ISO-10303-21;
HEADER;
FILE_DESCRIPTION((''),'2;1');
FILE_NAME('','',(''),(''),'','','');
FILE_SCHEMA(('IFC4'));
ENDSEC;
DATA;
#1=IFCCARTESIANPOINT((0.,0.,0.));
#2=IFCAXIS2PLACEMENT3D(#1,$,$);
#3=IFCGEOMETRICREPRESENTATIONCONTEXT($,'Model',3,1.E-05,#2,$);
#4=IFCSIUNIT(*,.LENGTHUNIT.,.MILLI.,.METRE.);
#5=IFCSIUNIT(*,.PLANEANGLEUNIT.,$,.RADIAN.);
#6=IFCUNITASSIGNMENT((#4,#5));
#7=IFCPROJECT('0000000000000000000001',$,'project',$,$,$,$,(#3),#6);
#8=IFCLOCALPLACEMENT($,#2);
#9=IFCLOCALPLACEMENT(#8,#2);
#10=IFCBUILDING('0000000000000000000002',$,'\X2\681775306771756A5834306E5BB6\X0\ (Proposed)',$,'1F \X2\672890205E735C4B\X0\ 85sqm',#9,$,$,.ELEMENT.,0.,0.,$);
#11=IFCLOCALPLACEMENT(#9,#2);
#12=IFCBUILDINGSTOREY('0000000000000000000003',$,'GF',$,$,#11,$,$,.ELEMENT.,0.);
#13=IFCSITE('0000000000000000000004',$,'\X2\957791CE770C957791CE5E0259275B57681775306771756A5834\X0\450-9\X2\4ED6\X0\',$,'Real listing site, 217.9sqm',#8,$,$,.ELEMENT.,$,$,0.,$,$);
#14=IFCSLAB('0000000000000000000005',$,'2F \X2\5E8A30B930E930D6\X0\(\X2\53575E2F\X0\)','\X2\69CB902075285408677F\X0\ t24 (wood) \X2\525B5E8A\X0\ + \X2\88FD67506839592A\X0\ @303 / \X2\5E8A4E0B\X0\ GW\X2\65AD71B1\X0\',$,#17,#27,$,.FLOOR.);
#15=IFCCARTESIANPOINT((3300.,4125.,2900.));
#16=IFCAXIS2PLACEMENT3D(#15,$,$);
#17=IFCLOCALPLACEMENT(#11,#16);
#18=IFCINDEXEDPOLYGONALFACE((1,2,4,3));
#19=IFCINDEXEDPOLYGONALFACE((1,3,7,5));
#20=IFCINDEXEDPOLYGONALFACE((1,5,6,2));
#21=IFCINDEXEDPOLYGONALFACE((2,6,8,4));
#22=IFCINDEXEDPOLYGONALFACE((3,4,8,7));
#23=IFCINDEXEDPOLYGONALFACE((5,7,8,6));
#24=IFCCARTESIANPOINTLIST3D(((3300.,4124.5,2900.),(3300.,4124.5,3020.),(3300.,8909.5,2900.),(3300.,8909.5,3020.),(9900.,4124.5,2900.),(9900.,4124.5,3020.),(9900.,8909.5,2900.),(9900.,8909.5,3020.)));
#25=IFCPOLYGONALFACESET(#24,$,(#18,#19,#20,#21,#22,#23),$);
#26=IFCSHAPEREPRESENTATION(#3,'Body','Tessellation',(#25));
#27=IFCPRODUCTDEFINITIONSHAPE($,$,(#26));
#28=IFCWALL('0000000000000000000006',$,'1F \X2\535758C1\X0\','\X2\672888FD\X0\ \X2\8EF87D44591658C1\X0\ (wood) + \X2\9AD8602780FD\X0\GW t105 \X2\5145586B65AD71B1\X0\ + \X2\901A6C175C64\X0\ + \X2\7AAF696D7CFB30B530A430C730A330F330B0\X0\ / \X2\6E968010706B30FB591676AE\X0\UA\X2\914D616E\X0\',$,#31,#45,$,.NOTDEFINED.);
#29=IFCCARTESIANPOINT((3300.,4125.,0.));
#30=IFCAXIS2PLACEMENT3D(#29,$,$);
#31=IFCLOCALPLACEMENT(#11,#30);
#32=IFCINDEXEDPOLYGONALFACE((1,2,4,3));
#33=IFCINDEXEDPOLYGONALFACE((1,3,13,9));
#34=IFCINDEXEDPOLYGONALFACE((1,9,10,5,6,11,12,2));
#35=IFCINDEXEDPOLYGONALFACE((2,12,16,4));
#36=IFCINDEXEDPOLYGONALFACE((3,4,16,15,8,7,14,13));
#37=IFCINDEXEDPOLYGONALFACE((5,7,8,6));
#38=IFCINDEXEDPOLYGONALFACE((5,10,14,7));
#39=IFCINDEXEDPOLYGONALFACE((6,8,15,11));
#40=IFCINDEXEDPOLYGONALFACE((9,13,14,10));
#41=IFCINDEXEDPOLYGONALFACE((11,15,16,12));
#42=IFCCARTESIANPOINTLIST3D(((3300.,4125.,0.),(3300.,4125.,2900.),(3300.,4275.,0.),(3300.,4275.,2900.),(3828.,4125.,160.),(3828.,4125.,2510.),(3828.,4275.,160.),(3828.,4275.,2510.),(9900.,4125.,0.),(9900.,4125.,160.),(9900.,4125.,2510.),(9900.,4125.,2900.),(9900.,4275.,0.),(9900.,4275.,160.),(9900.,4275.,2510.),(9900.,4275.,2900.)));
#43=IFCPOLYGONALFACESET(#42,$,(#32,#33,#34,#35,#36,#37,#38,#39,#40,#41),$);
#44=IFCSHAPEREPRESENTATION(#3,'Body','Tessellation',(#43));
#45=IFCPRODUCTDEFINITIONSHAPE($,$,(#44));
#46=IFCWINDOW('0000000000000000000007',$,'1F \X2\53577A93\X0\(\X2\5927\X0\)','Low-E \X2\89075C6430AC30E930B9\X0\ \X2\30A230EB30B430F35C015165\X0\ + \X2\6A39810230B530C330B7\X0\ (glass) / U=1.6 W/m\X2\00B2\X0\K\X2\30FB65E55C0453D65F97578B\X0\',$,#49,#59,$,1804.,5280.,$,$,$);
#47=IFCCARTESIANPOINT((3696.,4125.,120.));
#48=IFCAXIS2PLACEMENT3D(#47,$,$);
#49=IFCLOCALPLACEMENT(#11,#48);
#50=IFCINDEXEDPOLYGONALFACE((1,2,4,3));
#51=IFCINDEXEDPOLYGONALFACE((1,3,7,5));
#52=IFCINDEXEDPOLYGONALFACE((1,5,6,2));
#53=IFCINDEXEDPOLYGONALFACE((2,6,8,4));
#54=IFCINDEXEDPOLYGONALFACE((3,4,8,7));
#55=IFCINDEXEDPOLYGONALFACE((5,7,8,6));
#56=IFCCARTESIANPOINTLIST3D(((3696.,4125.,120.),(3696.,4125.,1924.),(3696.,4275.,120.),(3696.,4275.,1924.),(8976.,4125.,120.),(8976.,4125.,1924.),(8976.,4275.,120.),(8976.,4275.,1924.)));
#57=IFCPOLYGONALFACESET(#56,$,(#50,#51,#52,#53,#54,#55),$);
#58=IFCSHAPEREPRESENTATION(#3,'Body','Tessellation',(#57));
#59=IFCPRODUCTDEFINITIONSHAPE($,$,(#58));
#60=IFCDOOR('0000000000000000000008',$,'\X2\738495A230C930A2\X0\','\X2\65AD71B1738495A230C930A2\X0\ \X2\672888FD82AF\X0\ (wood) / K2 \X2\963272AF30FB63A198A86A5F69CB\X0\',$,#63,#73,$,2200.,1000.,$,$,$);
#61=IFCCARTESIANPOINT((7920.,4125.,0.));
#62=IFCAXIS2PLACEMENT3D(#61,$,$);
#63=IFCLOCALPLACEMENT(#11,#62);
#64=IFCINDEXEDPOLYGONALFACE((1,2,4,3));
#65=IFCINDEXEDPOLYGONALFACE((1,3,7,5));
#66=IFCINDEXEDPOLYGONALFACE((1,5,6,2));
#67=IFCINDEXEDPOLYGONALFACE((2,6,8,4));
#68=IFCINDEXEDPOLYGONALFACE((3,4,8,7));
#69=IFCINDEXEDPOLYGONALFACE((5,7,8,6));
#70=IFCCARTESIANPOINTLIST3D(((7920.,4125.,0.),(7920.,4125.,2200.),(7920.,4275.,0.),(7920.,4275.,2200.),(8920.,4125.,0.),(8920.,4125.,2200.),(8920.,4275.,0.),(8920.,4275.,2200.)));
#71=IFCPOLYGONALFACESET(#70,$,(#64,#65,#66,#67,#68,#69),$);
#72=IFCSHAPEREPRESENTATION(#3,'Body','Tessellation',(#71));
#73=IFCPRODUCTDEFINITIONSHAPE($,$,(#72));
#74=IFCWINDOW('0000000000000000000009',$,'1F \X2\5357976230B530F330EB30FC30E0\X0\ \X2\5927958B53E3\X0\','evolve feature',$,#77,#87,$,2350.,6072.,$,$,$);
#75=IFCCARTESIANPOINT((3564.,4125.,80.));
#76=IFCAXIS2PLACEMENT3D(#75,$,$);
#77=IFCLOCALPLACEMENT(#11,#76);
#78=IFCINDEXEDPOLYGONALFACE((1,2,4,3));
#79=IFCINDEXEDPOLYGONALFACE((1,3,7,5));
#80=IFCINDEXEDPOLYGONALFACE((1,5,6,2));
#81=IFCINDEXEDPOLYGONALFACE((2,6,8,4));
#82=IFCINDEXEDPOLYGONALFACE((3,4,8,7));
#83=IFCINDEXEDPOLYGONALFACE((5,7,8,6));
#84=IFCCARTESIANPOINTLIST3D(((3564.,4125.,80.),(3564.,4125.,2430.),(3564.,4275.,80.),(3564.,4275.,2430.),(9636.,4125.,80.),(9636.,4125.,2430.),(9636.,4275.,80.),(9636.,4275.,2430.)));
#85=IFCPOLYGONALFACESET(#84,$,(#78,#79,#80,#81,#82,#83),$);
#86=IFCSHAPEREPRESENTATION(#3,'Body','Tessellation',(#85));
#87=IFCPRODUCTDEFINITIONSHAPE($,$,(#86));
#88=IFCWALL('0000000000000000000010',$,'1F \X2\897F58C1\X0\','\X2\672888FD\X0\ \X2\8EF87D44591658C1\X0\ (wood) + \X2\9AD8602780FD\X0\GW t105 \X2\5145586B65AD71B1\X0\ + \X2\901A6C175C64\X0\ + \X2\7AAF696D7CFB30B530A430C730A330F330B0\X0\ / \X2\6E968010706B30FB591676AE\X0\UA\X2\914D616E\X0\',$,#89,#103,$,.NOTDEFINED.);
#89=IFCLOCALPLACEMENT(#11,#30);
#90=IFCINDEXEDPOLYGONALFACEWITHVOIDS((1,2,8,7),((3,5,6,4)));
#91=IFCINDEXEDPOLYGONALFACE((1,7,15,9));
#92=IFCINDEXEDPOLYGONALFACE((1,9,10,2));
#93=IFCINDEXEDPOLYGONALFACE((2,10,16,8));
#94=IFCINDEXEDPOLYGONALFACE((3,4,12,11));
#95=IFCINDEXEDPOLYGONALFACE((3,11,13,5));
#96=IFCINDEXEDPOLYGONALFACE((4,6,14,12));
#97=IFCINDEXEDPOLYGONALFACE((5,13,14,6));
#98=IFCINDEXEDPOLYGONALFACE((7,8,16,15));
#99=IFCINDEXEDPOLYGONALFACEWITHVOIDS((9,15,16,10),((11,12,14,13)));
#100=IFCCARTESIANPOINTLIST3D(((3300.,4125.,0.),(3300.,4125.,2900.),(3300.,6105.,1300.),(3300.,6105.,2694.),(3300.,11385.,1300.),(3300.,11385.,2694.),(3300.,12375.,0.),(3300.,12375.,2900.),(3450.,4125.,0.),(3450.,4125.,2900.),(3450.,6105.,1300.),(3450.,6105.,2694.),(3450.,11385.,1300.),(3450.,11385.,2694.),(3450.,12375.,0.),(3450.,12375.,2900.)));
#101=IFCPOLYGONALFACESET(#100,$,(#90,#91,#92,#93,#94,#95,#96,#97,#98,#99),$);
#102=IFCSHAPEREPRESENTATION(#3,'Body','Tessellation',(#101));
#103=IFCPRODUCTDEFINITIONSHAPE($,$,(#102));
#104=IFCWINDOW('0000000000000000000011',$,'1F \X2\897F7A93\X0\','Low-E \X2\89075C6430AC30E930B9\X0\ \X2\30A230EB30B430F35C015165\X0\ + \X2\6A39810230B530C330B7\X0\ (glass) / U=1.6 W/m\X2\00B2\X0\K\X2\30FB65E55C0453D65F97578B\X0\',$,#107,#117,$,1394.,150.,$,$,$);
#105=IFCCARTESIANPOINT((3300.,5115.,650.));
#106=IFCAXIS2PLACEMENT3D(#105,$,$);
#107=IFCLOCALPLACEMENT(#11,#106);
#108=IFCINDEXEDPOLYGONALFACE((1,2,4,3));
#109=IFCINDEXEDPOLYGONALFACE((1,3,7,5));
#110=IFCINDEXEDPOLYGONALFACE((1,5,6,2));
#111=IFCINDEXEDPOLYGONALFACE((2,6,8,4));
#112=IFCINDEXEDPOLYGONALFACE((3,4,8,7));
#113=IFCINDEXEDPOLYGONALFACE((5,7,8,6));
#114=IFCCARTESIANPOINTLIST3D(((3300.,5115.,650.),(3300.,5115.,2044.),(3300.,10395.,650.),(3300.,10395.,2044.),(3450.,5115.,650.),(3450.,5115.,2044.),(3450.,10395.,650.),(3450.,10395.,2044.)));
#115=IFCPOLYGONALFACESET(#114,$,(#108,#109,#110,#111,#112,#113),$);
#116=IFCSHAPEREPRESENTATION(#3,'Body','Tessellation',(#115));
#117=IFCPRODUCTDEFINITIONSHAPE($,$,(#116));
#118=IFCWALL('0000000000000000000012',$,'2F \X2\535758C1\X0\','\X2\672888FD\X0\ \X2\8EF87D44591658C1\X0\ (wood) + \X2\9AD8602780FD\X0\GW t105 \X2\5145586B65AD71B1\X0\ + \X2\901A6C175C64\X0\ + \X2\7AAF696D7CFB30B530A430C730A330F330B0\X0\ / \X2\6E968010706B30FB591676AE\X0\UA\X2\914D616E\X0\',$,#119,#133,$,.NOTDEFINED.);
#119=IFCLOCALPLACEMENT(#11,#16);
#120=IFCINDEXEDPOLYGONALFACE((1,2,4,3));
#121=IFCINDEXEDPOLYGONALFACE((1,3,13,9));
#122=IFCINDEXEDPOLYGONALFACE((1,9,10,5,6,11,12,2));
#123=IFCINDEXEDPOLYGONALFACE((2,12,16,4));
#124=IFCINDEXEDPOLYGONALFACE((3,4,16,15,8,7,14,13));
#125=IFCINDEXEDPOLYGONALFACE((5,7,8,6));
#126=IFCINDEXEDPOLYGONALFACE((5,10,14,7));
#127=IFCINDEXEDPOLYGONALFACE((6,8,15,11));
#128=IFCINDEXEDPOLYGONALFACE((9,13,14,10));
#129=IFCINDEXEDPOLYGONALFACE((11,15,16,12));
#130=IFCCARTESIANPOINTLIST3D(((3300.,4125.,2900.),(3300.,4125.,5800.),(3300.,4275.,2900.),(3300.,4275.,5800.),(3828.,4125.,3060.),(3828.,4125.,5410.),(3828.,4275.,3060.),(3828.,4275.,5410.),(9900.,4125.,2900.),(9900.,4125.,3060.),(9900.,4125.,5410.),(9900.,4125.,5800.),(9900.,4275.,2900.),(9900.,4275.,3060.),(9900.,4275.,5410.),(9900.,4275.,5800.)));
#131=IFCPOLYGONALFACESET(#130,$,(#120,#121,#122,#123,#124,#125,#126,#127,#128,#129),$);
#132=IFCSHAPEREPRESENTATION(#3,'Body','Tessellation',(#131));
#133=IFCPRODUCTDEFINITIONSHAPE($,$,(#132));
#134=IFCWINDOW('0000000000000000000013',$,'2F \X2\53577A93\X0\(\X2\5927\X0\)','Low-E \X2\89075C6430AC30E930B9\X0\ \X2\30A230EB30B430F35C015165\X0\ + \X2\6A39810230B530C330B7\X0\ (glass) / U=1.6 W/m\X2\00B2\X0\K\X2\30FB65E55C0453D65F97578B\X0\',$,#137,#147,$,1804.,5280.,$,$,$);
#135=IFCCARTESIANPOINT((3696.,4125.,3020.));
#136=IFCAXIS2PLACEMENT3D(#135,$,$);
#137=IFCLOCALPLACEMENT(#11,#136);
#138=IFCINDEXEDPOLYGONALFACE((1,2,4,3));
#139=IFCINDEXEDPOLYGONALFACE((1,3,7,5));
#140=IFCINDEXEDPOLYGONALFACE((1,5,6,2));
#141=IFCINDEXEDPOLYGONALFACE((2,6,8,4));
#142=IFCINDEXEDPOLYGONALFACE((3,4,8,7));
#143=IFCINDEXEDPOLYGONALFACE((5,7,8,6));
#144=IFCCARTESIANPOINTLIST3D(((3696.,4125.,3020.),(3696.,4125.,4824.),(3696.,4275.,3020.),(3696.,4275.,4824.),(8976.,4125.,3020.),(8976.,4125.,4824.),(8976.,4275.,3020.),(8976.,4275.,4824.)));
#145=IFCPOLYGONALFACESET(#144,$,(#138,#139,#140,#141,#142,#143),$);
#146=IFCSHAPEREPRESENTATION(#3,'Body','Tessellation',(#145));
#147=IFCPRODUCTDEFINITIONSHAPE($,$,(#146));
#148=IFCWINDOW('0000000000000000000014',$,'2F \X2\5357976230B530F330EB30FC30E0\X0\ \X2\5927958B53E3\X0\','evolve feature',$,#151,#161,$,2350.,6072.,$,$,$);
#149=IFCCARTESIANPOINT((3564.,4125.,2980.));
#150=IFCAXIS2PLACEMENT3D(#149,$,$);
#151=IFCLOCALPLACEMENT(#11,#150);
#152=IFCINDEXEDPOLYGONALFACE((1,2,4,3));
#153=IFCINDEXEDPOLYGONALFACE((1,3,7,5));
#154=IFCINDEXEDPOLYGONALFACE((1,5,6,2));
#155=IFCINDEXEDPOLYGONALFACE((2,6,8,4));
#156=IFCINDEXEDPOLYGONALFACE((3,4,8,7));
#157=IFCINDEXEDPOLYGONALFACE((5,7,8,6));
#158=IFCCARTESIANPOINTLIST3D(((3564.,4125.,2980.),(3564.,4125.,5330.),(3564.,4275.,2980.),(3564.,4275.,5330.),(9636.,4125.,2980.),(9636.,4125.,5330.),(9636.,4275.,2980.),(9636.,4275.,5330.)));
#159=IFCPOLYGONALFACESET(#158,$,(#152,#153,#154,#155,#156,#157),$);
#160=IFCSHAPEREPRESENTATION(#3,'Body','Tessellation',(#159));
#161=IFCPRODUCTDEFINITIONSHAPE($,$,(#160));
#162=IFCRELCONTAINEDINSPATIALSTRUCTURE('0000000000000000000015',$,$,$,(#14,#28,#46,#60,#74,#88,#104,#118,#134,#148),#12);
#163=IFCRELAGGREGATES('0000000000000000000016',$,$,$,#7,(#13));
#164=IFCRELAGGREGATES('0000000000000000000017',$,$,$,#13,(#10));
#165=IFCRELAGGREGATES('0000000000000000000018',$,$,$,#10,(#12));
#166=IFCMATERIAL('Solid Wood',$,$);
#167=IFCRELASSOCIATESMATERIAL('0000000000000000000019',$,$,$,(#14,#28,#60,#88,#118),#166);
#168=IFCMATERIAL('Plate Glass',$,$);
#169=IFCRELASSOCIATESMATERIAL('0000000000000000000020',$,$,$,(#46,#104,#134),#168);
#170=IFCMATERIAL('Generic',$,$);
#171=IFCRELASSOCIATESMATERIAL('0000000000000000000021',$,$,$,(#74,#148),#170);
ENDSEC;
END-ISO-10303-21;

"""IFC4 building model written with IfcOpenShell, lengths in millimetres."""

from ifc_helpers import new_model, si_unit, frame, frame_2d, origin, place, context, project, spatial, rectangle, extrude, material, element, fill, save


model = new_model("IFC4")

# Units and contexts
model_context = context("Model", 3, precision=1e-05, world=origin())
ifc_project = project(units=[si_unit("LENGTHUNIT", "METRE", prefix="MILLI"), si_unit("PLANEANGLEUNIT", "RADIAN")], contexts=[model_context])

# Site, building, storey
site_placement = place(None, origin())
site = spatial("IfcSite", under=ifc_project, at=site_placement, Name="長野県長野市大字栗田東番場450-9他", ObjectType="Real listing site, 217.9sqm", CompositionType="ELEMENT", RefElevation=0.0)
building_placement = place(site_placement, origin())
building = spatial("IfcBuilding", under=site, at=building_placement, Name="栗田東番場の家 (Proposed)", ObjectType="1F 木造平屋 85sqm", CompositionType="ELEMENT", ElevationOfRefHeight=0.0, ElevationOfTerrain=0.0)
storey_placement = place(building_placement, origin())
storey = spatial("IfcBuildingStorey", under=building, at=storey_placement, Name="GF", CompositionType="ELEMENT", Elevation=0.0)

# Slab
ifc_material_1 = material(Name="Solid Wood")
slab_1_placement = place(storey_placement, frame((3300.0, 4125.0, 2900.0)))
element("IfcSlab", 1, at=slab_1_placement, inside=storey, material=ifc_material_1, Name="2F 床スラブ(南帯)", Description="構造用合板 t24 (wood) 剛床 + 製材根太 @303 / 床下 GW断熱", PredefinedType="FLOOR", context=model_context, shape_type="SweptSolid", body=[
    extrude(rectangle(XDim=6600.0, YDim=4785.0, at=frame_2d((3300.0, 2392.0))), frame((3300.0, 4125.0, 2900.0)), (0.0, 0.0, 1.0), 120.0),
])
ifc_material_2 = material(Name="Generic")

# Wall, openings, windows, door
wall_1_placement = place(storey_placement, frame((3300.0, 4125.0, 0.0)))
wall_1 = element("IfcWall", 2, at=wall_1_placement, inside=storey, material=ifc_material_1, Name="1F 南壁", Description="木製 軸組外壁 (wood) + 高性能GW t105 充填断熱 + 通気層 + 窯業系サイディング / 準耐火・外皮UA配慮", PredefinedType="NOTDEFINED", context=model_context, shape_type="SweptSolid", body=[
    extrude(rectangle(XDim=6600.0, YDim=150.0, at=frame_2d((3300.0, 75.0))), frame((3300.0, 4125.0, 0.0)), (0.0, 0.0, 1.0), 2900.0),
])
opening_1_placement = place(storey_placement, frame((3696.0, 4125.0, 120.0)))
opening_1 = element("IfcOpeningElement", 3, at=opening_1_placement, cuts=wall_1, PredefinedType="NOTDEFINED", context=model_context, shape_type="SweptSolid", body=[
    extrude(rectangle(XDim=5280.0, YDim=150.0, at=frame_2d((2640.0, 75.0))), frame((3696.0, 4125.0, 120.0)), (0.0, 0.0, 1.0), 1804.0),
])
opening_2_placement = place(storey_placement, frame((7920.0, 4125.0, 0.0)))
opening_2 = element("IfcOpeningElement", 4, at=opening_2_placement, cuts=wall_1, PredefinedType="NOTDEFINED", context=model_context, shape_type="SweptSolid", body=[
    extrude(rectangle(XDim=1000.0, YDim=150.0, at=frame_2d((500.0, 75.0))), frame((7920.0, 4125.0, 0.0)), (0.0, 0.0, 1.0), 2200.0),
])
opening_3_placement = place(storey_placement, frame((3564.0, 4125.0, 80.0)))
opening_3 = element("IfcOpeningElement", 5, at=opening_3_placement, cuts=wall_1, PredefinedType="NOTDEFINED", context=model_context, shape_type="SweptSolid", body=[
    extrude(rectangle(XDim=6072.0, YDim=150.0, at=frame_2d((3036.0, 75.0))), frame((3564.0, 4125.0, 80.0)), (0.0, 0.0, 1.0), 2350.0),
])
ifc_material_3 = material(Name="Plate Glass")
window_1_placement = place(storey_placement, frame((3696.0, 4125.0, 120.0)))
window_1 = element("IfcWindow", 6, at=window_1_placement, inside=storey, material=ifc_material_3, Name="1F 南窓(大)", Description="Low-E 複層ガラス アルゴン封入 + 樹脂サッシ (glass) / U=1.6 W/m²K・日射取得型", OverallHeight=1804.0, OverallWidth=5280.0, context=model_context, shape_type="SweptSolid", body=[
    extrude(rectangle(XDim=5280.0, YDim=150.0, at=frame_2d((2640.0, 75.0))), frame((3696.0, 4125.0, 120.0)), (0.0, 0.0, 1.0), 1804.0),
])
fill(opening_1, window_1)
door_placement = place(storey_placement, frame((7920.0, 4125.0, 0.0)))
door = element("IfcDoor", 7, at=door_placement, inside=storey, material=ifc_material_1, Name="玄関ドア", Description="断熱玄関ドア 木製芯 (wood) / K2 防犯・採風機構", OverallHeight=2200.0, OverallWidth=1000.0, context=model_context, shape_type="SweptSolid", body=[
    extrude(rectangle(XDim=1000.0, YDim=150.0, at=frame_2d((500.0, 75.0))), frame((7920.0, 4125.0, 0.0)), (0.0, 0.0, 1.0), 2200.0),
])
fill(opening_2, door)
window_2_placement = place(storey_placement, frame((3564.0, 4125.0, 80.0)))
window_2 = element("IfcWindow", 8, at=window_2_placement, inside=storey, material=ifc_material_2, Name="1F 南面サンルーム 大開口", Description="evolve feature", OverallHeight=2350.0, OverallWidth=6072.0, context=model_context, shape_type="SweptSolid", body=[
    extrude(rectangle(XDim=6072.0, YDim=150.0, at=frame_2d((3036.0, 75.0))), frame((3564.0, 4125.0, 80.0)), (0.0, 0.0, 1.0), 2350.0),
])
fill(opening_3, window_2)

# Wall, opening, window
wall_2_placement = place(storey_placement, frame((3300.0, 4125.0, 0.0)))
wall_2 = element("IfcWall", 9, at=wall_2_placement, inside=storey, material=ifc_material_1, Name="1F 西壁", Description="木製 軸組外壁 (wood) + 高性能GW t105 充填断熱 + 通気層 + 窯業系サイディング / 準耐火・外皮UA配慮", PredefinedType="NOTDEFINED", context=model_context, shape_type="SweptSolid", body=[
    extrude(rectangle(XDim=150.0, YDim=8250.0, at=frame_2d((75.0, 4125.0))), frame((3300.0, 4125.0, 0.0)), (0.0, 0.0, 1.0), 2900.0),
])
opening_4_placement = place(storey_placement, frame((3300.0, 5115.0, 650.0)))
opening_4 = element("IfcOpeningElement", 10, at=opening_4_placement, cuts=wall_2, PredefinedType="NOTDEFINED", context=model_context, shape_type="SweptSolid", body=[
    extrude(rectangle(XDim=150.0, YDim=5280.0, at=frame_2d((75.0, 2640.0))), frame((3300.0, 5115.0, 650.0)), (0.0, 0.0, 1.0), 1394.0),
])
window_3_placement = place(storey_placement, frame((3300.0, 5115.0, 650.0)))
window_3 = element("IfcWindow", 11, at=window_3_placement, inside=storey, material=ifc_material_3, Name="1F 西窓", Description="Low-E 複層ガラス アルゴン封入 + 樹脂サッシ (glass) / U=1.6 W/m²K・日射取得型", OverallHeight=1394.0, OverallWidth=150.0, context=model_context, shape_type="SweptSolid", body=[
    extrude(rectangle(XDim=150.0, YDim=5280.0, at=frame_2d((75.0, 2640.0))), frame((3300.0, 5115.0, 650.0)), (0.0, 0.0, 1.0), 1394.0),
])
fill(opening_4, window_3)

# Wall, openings, windows
wall_3_placement = place(storey_placement, frame((3300.0, 4125.0, 2900.0)))
wall_3 = element("IfcWall", 12, at=wall_3_placement, inside=storey, material=ifc_material_1, Name="2F 南壁", Description="木製 軸組外壁 (wood) + 高性能GW t105 充填断熱 + 通気層 + 窯業系サイディング / 準耐火・外皮UA配慮", PredefinedType="NOTDEFINED", context=model_context, shape_type="SweptSolid", body=[
    extrude(rectangle(XDim=6600.0, YDim=150.0, at=frame_2d((3300.0, 75.0))), frame((3300.0, 4125.0, 2900.0)), (0.0, 0.0, 1.0), 2900.0),
])
opening_5_placement = place(storey_placement, frame((3696.0, 4125.0, 3020.0)))
opening_5 = element("IfcOpeningElement", 13, at=opening_5_placement, cuts=wall_3, PredefinedType="NOTDEFINED", context=model_context, shape_type="SweptSolid", body=[
    extrude(rectangle(XDim=5280.0, YDim=150.0, at=frame_2d((2640.0, 75.0))), frame((3696.0, 4125.0, 3020.0)), (0.0, 0.0, 1.0), 1804.0),
])
opening_6_placement = place(storey_placement, frame((3564.0, 4125.0, 2980.0)))
opening_6 = element("IfcOpeningElement", 14, at=opening_6_placement, cuts=wall_3, PredefinedType="NOTDEFINED", context=model_context, shape_type="SweptSolid", body=[
    extrude(rectangle(XDim=6072.0, YDim=150.0, at=frame_2d((3036.0, 75.0))), frame((3564.0, 4125.0, 2980.0)), (0.0, 0.0, 1.0), 2350.0),
])
window_4_placement = place(storey_placement, frame((3696.0, 4125.0, 3020.0)))
window_4 = element("IfcWindow", 15, at=window_4_placement, inside=storey, material=ifc_material_3, Name="2F 南窓(大)", Description="Low-E 複層ガラス アルゴン封入 + 樹脂サッシ (glass) / U=1.6 W/m²K・日射取得型", OverallHeight=1804.0, OverallWidth=5280.0, context=model_context, shape_type="SweptSolid", body=[
    extrude(rectangle(XDim=5280.0, YDim=150.0, at=frame_2d((2640.0, 75.0))), frame((3696.0, 4125.0, 3020.0)), (0.0, 0.0, 1.0), 1804.0),
])
fill(opening_5, window_4)
window_5_placement = place(storey_placement, frame((3564.0, 4125.0, 2980.0)))
window_5 = element("IfcWindow", 16, at=window_5_placement, inside=storey, material=ifc_material_2, Name="2F 南面サンルーム 大開口", Description="evolve feature", OverallHeight=2350.0, OverallWidth=6072.0, context=model_context, shape_type="SweptSolid", body=[
    extrude(rectangle(XDim=6072.0, YDim=150.0, at=frame_2d((3036.0, 75.0))), frame((3564.0, 4125.0, 2980.0)), (0.0, 0.0, 1.0), 2350.0),
])
fill(opening_6, window_5)

save(model, "model.ifc")
